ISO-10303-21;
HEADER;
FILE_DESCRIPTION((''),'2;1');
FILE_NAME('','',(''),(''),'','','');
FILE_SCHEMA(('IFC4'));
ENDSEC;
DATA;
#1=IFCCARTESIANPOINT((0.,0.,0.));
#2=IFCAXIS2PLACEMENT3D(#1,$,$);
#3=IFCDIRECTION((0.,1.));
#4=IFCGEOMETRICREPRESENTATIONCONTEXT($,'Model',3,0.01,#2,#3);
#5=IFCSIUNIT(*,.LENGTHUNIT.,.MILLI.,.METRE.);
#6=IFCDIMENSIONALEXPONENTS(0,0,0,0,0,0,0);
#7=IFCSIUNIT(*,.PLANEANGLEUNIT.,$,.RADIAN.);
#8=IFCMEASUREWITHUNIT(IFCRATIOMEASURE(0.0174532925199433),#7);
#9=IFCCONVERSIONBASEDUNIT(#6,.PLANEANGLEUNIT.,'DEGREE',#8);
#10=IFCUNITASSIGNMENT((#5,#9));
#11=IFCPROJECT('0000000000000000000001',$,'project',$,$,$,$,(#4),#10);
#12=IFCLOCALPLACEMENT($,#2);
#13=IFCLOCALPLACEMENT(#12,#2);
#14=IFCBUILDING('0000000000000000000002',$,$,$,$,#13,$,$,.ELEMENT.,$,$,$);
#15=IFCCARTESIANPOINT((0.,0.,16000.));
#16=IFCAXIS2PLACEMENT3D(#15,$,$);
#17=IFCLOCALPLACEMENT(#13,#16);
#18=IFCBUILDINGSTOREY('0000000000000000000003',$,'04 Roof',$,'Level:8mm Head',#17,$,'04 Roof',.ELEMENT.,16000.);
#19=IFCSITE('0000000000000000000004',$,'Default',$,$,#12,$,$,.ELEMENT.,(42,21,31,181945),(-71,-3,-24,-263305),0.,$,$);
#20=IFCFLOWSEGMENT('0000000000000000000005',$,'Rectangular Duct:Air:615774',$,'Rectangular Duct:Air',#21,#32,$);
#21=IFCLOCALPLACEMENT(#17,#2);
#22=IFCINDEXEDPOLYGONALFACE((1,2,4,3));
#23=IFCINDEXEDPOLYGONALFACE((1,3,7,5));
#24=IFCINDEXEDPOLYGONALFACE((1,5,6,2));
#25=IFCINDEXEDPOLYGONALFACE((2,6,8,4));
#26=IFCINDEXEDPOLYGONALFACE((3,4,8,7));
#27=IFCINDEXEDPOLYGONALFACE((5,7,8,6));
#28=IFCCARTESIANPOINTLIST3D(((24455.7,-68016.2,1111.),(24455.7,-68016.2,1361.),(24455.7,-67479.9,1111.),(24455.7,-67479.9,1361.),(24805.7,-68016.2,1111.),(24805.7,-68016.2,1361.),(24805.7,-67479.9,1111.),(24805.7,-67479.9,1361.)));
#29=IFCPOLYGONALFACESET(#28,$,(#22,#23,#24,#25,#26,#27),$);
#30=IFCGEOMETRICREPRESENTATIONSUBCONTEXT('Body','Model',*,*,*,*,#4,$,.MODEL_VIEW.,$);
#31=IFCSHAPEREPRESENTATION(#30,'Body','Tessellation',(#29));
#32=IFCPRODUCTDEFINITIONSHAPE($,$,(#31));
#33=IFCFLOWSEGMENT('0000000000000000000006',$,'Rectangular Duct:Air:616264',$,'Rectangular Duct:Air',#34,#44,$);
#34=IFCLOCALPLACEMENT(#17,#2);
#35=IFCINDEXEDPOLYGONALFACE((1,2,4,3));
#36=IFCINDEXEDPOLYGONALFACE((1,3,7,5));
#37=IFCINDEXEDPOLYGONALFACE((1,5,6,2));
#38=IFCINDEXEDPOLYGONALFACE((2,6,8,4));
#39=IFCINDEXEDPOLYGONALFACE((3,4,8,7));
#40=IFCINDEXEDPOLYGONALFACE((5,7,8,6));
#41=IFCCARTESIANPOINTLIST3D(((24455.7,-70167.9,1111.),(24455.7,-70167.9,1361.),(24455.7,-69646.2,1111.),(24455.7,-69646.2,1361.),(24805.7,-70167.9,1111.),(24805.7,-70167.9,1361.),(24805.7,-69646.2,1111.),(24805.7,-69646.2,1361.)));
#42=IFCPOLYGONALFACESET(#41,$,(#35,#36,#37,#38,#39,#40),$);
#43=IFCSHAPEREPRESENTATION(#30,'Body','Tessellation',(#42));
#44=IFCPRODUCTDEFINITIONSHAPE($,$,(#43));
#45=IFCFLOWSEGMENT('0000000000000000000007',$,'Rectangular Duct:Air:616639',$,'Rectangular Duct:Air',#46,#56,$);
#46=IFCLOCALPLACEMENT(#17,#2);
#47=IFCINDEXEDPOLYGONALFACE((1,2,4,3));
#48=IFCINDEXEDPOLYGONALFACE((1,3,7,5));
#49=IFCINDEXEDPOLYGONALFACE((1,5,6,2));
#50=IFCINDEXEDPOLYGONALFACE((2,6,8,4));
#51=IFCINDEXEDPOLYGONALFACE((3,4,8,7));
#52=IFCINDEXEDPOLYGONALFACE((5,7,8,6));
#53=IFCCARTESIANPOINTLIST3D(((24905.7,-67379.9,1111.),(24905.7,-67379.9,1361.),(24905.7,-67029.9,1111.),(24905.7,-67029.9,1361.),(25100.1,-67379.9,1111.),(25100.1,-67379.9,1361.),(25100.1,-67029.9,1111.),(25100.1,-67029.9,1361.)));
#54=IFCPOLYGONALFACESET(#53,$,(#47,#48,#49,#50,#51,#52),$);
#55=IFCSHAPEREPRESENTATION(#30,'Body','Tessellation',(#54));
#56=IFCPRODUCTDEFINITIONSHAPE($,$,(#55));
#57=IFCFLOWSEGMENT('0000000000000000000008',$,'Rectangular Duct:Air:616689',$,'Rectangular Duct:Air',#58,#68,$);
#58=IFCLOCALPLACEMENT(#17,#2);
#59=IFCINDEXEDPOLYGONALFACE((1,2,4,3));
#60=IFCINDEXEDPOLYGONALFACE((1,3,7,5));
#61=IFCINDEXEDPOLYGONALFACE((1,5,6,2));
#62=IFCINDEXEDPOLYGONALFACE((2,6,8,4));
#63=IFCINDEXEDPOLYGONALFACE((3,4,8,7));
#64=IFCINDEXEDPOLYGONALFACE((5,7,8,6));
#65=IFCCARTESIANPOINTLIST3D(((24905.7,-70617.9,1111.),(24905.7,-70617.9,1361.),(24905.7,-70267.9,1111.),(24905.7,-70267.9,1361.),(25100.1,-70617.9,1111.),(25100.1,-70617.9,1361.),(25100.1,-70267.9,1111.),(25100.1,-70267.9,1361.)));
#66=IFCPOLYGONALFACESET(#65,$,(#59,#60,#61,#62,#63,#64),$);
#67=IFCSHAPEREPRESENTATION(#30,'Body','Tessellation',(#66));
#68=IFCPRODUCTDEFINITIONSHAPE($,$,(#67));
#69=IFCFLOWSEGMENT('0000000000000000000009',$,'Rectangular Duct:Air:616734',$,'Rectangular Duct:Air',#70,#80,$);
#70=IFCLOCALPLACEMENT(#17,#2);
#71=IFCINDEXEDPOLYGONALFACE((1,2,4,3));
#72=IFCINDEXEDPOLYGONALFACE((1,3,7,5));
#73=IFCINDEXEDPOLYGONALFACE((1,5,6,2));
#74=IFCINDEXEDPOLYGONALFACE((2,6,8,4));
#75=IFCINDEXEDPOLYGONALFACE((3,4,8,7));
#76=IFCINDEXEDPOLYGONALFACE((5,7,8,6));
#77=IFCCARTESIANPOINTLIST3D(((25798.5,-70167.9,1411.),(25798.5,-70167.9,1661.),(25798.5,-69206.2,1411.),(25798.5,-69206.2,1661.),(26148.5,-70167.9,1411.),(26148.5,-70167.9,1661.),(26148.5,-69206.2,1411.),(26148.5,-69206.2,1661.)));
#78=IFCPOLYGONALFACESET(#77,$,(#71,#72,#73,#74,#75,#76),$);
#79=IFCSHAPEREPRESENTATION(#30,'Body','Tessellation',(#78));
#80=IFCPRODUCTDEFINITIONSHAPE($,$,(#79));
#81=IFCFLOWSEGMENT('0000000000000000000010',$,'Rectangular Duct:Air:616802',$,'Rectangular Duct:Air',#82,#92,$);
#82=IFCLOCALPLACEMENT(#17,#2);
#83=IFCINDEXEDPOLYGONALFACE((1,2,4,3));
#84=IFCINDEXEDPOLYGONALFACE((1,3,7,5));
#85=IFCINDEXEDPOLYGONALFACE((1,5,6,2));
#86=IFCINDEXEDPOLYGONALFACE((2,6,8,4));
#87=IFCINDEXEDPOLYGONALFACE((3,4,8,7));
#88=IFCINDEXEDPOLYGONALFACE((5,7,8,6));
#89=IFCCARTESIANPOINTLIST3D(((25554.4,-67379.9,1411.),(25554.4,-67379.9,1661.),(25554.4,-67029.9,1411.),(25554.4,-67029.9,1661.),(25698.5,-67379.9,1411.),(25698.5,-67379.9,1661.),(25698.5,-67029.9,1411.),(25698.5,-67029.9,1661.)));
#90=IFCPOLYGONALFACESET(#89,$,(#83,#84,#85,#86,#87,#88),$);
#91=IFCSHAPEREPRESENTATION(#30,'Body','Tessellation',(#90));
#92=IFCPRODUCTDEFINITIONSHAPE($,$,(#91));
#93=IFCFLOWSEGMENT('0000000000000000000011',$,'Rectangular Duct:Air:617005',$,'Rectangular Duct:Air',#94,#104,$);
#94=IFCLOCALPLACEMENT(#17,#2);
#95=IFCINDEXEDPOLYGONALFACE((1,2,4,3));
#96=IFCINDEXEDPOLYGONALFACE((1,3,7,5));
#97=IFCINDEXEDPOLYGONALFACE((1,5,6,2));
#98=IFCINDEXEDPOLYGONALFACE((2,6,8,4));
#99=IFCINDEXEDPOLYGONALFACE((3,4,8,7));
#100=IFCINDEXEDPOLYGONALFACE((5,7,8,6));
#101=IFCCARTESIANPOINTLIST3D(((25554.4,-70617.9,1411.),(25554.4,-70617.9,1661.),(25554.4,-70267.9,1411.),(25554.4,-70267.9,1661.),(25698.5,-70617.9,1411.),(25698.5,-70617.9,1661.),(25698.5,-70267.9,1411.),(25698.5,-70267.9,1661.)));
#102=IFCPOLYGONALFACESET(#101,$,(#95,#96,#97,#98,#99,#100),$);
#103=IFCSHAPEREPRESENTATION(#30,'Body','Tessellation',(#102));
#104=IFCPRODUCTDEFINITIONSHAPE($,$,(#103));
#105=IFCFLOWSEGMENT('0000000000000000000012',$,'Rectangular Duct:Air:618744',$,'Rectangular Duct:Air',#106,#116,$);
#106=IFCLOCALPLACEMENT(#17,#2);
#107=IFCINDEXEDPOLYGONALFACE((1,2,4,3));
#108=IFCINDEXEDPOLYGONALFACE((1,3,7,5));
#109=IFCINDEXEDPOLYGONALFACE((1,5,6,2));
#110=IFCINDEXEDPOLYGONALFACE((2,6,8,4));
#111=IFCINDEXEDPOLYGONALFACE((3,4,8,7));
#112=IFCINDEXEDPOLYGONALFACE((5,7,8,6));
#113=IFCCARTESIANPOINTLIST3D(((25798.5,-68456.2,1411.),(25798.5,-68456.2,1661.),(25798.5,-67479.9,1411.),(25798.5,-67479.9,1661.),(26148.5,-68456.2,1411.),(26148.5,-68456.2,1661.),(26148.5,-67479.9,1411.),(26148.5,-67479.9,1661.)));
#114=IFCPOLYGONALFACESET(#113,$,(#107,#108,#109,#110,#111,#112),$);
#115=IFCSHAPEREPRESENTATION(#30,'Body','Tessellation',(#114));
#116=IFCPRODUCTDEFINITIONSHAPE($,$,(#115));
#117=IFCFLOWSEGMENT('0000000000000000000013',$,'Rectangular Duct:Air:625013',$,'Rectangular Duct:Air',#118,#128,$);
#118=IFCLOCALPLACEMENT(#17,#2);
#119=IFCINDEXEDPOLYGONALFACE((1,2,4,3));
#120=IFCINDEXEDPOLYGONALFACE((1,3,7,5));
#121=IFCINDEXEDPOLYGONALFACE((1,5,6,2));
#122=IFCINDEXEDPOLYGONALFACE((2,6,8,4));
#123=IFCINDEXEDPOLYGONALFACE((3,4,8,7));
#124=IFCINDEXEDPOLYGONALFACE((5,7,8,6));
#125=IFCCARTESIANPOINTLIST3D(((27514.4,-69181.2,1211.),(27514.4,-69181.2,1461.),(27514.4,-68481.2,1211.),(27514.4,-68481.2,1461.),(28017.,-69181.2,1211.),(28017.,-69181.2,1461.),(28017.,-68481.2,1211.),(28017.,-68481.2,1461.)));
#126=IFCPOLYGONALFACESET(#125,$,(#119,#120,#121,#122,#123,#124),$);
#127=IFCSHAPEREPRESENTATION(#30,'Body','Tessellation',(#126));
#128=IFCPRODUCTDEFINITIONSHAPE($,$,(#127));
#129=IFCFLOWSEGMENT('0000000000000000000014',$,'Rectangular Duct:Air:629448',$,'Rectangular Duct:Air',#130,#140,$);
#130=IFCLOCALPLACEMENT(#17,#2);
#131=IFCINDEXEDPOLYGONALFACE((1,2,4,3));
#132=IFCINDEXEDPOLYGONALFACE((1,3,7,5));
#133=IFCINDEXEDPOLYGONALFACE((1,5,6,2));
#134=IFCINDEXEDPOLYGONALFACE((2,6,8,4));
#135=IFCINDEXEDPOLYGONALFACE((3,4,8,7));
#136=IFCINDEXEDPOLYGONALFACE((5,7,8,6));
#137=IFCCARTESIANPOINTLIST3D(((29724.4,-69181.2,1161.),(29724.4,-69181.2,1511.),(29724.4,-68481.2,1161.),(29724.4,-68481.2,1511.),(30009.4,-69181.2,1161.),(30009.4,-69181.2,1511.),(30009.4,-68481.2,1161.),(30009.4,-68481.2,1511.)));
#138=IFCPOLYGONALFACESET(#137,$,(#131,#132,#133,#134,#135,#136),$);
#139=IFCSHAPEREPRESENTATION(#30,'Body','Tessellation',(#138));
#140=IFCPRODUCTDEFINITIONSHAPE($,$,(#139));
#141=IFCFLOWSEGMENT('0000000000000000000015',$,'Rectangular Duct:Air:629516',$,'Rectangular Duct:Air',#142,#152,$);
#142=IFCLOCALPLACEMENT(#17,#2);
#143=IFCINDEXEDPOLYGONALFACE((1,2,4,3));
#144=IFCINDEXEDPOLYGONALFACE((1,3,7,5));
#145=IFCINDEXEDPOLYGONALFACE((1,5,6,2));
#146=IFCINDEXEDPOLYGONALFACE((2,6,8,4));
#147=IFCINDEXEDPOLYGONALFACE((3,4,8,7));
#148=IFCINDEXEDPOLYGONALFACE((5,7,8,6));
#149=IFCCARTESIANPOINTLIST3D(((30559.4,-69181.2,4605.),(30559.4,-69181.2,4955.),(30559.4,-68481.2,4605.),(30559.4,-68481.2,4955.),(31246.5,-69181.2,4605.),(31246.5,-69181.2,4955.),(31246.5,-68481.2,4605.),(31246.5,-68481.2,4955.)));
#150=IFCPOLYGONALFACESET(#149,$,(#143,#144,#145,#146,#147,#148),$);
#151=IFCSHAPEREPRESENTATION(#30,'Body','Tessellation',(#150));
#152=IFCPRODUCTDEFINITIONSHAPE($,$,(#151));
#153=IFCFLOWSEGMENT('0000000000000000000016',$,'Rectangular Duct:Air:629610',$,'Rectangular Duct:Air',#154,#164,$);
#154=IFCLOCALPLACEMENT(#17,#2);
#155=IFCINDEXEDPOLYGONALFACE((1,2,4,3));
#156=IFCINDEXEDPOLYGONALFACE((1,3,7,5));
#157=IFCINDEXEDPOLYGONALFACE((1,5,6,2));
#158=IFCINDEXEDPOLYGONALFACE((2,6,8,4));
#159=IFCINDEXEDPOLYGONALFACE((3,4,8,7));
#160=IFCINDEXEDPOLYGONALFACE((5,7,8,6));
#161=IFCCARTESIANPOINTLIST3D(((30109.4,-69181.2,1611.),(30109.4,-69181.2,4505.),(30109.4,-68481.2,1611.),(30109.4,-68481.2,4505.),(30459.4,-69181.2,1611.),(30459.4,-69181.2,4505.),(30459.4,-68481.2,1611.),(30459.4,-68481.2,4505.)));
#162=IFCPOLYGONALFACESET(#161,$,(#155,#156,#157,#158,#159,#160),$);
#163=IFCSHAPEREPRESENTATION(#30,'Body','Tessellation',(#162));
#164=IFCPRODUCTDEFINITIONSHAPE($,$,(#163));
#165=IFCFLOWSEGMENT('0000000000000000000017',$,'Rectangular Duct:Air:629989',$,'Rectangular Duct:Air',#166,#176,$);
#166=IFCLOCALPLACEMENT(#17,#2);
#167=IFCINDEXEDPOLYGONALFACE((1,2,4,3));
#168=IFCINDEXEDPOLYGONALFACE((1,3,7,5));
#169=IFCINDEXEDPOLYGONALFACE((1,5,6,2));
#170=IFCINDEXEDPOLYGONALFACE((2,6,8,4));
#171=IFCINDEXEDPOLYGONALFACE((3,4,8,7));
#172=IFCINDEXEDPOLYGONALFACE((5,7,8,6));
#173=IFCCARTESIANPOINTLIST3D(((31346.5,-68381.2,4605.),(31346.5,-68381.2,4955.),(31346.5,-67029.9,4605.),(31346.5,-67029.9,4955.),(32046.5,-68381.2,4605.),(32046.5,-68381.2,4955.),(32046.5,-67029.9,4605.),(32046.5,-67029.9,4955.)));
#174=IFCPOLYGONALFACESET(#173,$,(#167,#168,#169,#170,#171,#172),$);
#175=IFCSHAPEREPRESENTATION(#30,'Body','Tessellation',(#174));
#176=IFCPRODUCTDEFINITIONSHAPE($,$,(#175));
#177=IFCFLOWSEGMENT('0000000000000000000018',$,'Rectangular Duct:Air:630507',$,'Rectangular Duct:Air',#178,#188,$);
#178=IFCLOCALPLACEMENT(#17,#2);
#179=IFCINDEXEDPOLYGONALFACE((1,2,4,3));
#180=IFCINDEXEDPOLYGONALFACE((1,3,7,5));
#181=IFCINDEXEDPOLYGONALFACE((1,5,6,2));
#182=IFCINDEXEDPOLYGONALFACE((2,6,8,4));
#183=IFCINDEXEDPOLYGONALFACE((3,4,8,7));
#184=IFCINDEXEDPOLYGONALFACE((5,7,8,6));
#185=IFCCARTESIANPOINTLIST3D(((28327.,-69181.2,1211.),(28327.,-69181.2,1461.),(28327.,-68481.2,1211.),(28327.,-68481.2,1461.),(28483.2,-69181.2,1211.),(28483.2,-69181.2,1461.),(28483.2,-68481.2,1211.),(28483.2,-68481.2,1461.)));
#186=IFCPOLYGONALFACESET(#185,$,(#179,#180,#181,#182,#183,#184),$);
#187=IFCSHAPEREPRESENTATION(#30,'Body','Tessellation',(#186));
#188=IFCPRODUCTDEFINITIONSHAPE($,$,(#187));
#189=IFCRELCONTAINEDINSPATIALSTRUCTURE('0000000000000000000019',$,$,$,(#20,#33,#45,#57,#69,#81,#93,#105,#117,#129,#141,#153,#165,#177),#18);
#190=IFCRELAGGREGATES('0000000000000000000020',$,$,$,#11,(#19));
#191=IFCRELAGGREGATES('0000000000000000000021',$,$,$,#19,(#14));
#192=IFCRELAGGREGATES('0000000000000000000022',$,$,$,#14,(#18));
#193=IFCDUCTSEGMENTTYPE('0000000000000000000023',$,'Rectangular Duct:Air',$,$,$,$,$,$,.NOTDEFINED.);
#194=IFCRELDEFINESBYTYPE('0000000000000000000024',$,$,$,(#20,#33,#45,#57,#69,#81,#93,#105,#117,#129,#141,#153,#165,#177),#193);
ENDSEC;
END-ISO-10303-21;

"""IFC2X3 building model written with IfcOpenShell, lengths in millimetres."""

from ifc_helpers import new_model, entity, si_unit, converted_unit, direction, frame, frame_2d, origin, origin_2d_with_axis, place, context, subcontext, project, spatial, rectangle, extrude, type_object, element, save


model = new_model("IFC2X3")

# Units and contexts
model_context = context("Model", 3, precision=0.01, world=origin(), true_north=direction((0.0, 1.0)))
body_context = subcontext(model_context, "Body", "Model", "MODEL_VIEW")
ifc_project = project(units=[si_unit("LENGTHUNIT", "METRE", prefix="MILLI"), converted_unit("PLANEANGLEUNIT", "DEGREE", entity("IfcRatioMeasure", 0.0174532925199433), si_unit("PLANEANGLEUNIT", "RADIAN"), dimensions=[0, 0, 0, 0, 0, 0, 0])], contexts=[model_context])

# Site, building, storey
site_placement = place(None, origin())
site = spatial("IfcSite", under=ifc_project, at=site_placement, Name="Default", CompositionType="ELEMENT", RefLatitude=(42, 21, 31, 181945), RefLongitude=(-71, -3, -24, -263305), RefElevation=0.0)
building_placement = place(site_placement, origin())
building = spatial("IfcBuilding", under=site, at=building_placement, CompositionType="ELEMENT")
storey_placement = place(building_placement, frame((0.0, 0.0, 16000.0)))
storey = spatial("IfcBuildingStorey", under=building, at=storey_placement, Name="04 Roof", ObjectType="Level:8mm Head", LongName="04 Roof", CompositionType="ELEMENT", Elevation=16000.0)

# Flow segments
duct_segment_type = type_object("IfcDuctSegmentType", Name="Rectangular Duct:Air", PredefinedType="NOTDEFINED")
flow_segment_1_placement = place(storey_placement, frame((24455.7, -68016.2, 1111.0)))
element("IfcFlowSegment", 1, at=flow_segment_1_placement, inside=storey, type_object=duct_segment_type, Name="Rectangular Duct:Air:615774", ObjectType="Rectangular Duct:Air", context=body_context, shape_type="SweptSolid", body=[
    extrude(rectangle(XDim=536.3, YDim=350.0, at=frame_2d((0.0, 0.0), x_axis=(1.0, 0.0))), frame((175.0, 268.2, 0.0), z_axis=(0.0, 0.0, 1.0), x_axis=(0.0, -1.0, 0.0)), (0.0, 0.0, 1.0), 250.0),
])
flow_segment_2_placement = place(storey_placement, frame((24455.7, -70167.9, 1111.0)))
element("IfcFlowSegment", 2, at=flow_segment_2_placement, inside=storey, type_object=duct_segment_type, Name="Rectangular Duct:Air:616264", ObjectType="Rectangular Duct:Air", context=body_context, shape_type="SweptSolid", body=[
    extrude(rectangle(XDim=521.7, YDim=350.0, at=origin_2d_with_axis()), frame((175.0, 260.9, 0.0), z_axis=(0.0, 0.0, 1.0), x_axis=(0.0, 1.0, 0.0)), (0.0, 0.0, 1.0), 250.0),
])
flow_segment_3_placement = place(storey_placement, frame((24905.7, -67379.9, 1111.0)))
element("IfcFlowSegment", 3, at=flow_segment_3_placement, inside=storey, type_object=duct_segment_type, Name="Rectangular Duct:Air:616639", ObjectType="Rectangular Duct:Air", context=body_context, shape_type="SweptSolid", body=[
    extrude(rectangle(XDim=194.4, YDim=350.0, at=frame_2d((0.0, 0.0), x_axis=(1.0, 0.0))), frame((97.2, 175.0, 0.0)), (0.0, 0.0, 1.0), 250.0),
])
flow_segment_4_placement = place(storey_placement, frame((24905.7, -70617.9, 1111.0)))
element("IfcFlowSegment", 4, at=flow_segment_4_placement, inside=storey, type_object=duct_segment_type, Name="Rectangular Duct:Air:616689", ObjectType="Rectangular Duct:Air", context=body_context, shape_type="SweptSolid", body=[
    extrude(rectangle(XDim=194.4, YDim=350.0, at=frame_2d((0.0, 0.0), x_axis=(1.0, 0.0))), frame((97.2, 175.0, 0.0)), (0.0, 0.0, 1.0), 250.0),
])
flow_segment_5_placement = place(storey_placement, frame((25798.5, -70167.9, 1411.0)))
element("IfcFlowSegment", 5, at=flow_segment_5_placement, inside=storey, type_object=duct_segment_type, Name="Rectangular Duct:Air:616734", ObjectType="Rectangular Duct:Air", context=body_context, shape_type="SweptSolid", body=[
    extrude(rectangle(XDim=961.7, YDim=350.0, at=frame_2d((0.0, 0.0), x_axis=(1.0, 0.0))), frame((175.0, 480.9, 0.0), z_axis=(0.0, 0.0, 1.0), x_axis=(0.0, -1.0, 0.0)), (0.0, 0.0, 1.0), 250.0),
])
flow_segment_6_placement = place(storey_placement, frame((25554.4, -67379.9, 1411.0)))
element("IfcFlowSegment", 6, at=flow_segment_6_placement, inside=storey, type_object=duct_segment_type, Name="Rectangular Duct:Air:616802", ObjectType="Rectangular Duct:Air", context=body_context, shape_type="SweptSolid", body=[
    extrude(rectangle(XDim=144.1, YDim=350.0, at=frame_2d((0.0, 0.0), x_axis=(1.0, 0.0))), frame((72.0, 175.0, 0.0), z_axis=(0.0, 0.0, 1.0), x_axis=(-1.0, 0.0, 0.0)), (0.0, 0.0, 1.0), 250.0),
])
flow_segment_7_placement = place(storey_placement, frame((25554.4, -70617.9, 1411.0)))
element("IfcFlowSegment", 7, at=flow_segment_7_placement, inside=storey, type_object=duct_segment_type, Name="Rectangular Duct:Air:617005", ObjectType="Rectangular Duct:Air", context=body_context, shape_type="SweptSolid", body=[
    extrude(rectangle(XDim=144.1, YDim=350.0, at=frame_2d((0.0, 0.0), x_axis=(1.0, 0.0))), frame((72.0, 175.0, 0.0), z_axis=(0.0, 0.0, 1.0), x_axis=(-1.0, 0.0, 0.0)), (0.0, 0.0, 1.0), 250.0),
])
flow_segment_8_placement = place(storey_placement, frame((25798.5, -68456.2, 1411.0)))
element("IfcFlowSegment", 8, at=flow_segment_8_placement, inside=storey, type_object=duct_segment_type, Name="Rectangular Duct:Air:618744", ObjectType="Rectangular Duct:Air", context=body_context, shape_type="SweptSolid", body=[
    extrude(rectangle(XDim=976.3, YDim=350.0, at=frame_2d((0.0, 0.0), x_axis=(1.0, 0.0))), frame((175.0, 488.2, 0.0), z_axis=(0.0, 0.0, 1.0), x_axis=(0.0, -1.0, 0.0)), (0.0, 0.0, 1.0), 250.0),
])
flow_segment_9_placement = place(storey_placement, frame((27514.4, -69181.2, 1211.0)))
element("IfcFlowSegment", 9, at=flow_segment_9_placement, inside=storey, type_object=duct_segment_type, Name="Rectangular Duct:Air:625013", ObjectType="Rectangular Duct:Air", context=body_context, shape_type="SweptSolid", body=[
    extrude(rectangle(XDim=502.6, YDim=700.0, at=frame_2d((0.0, 0.0), x_axis=(1.0, 0.0))), frame((251.3, 350.0, 0.0)), (0.0, 0.0, 1.0), 250.0),
])
flow_segment_10_placement = place(storey_placement, frame((29724.4, -69181.2, 1161.0)))
element("IfcFlowSegment", 10, at=flow_segment_10_placement, inside=storey, type_object=duct_segment_type, Name="Rectangular Duct:Air:629448", ObjectType="Rectangular Duct:Air", context=body_context, shape_type="SweptSolid", body=[
    extrude(rectangle(XDim=285.0, YDim=700.0, at=frame_2d((0.0, 0.0), x_axis=(1.0, 0.0))), frame((142.5, 350.0, 0.0)), (0.0, 0.0, 1.0), 350.0),
])
flow_segment_11_placement = place(storey_placement, frame((30559.4, -69181.2, 4605.0)))
element("IfcFlowSegment", 11, at=flow_segment_11_placement, inside=storey, type_object=duct_segment_type, Name="Rectangular Duct:Air:629516", ObjectType="Rectangular Duct:Air", context=body_context, shape_type="SweptSolid", body=[
    extrude(rectangle(XDim=687.1, YDim=700.0, at=frame_2d((0.0, 0.0), x_axis=(1.0, 0.0))), frame((343.6, 350.0, 0.0), z_axis=(0.0, 0.0, 1.0), x_axis=(-1.0, 0.0, 0.0)), (0.0, 0.0, 1.0), 350.0),
])
flow_segment_12_placement = place(storey_placement, frame((30109.4, -69181.2, 1611.0)))
element("IfcFlowSegment", 12, at=flow_segment_12_placement, inside=storey, type_object=duct_segment_type, Name="Rectangular Duct:Air:629610", ObjectType="Rectangular Duct:Air", context=body_context, shape_type="SweptSolid", body=[
    extrude(rectangle(XDim=350.0, YDim=700.0, at=frame_2d((0.0, 0.0), x_axis=(1.0, 0.0))), frame((175.0, 350.0, 0.0), z_axis=(0.0, 0.0, 1.0), x_axis=(-1.0, 0.0, 0.0)), (0.0, 0.0, 1.0), 2894.0),
])
flow_segment_13_placement = place(storey_placement, frame((31346.5, -68381.2, 4605.0)))
element("IfcFlowSegment", 13, at=flow_segment_13_placement, inside=storey, type_object=duct_segment_type, Name="Rectangular Duct:Air:629989", ObjectType="Rectangular Duct:Air", context=body_context, shape_type="SweptSolid", body=[
    extrude(rectangle(XDim=1351.3, YDim=700.0, at=origin_2d_with_axis()), frame((350.0, 675.7, 0.0), z_axis=(0.0, 0.0, 1.0), x_axis=(0.0, -1.0, 0.0)), (0.0, 0.0, 1.0), 350.0),
])
flow_segment_14_placement = place(storey_placement, frame((28327.0, -69181.2, 1211.0)))
element("IfcFlowSegment", 14, at=flow_segment_14_placement, inside=storey, type_object=duct_segment_type, Name="Rectangular Duct:Air:630507", ObjectType="Rectangular Duct:Air", context=body_context, shape_type="SweptSolid", body=[
    extrude(rectangle(XDim=156.2, YDim=700.0, at=frame_2d((0.0, 0.0), x_axis=(1.0, 0.0))), frame((78.1, 350.0, 0.0), z_axis=(0.0, 0.0, 1.0), x_axis=(-1.0, 0.0, 0.0)), (0.0, 0.0, 1.0), 250.0),
])

save(model, "model.ifc")
